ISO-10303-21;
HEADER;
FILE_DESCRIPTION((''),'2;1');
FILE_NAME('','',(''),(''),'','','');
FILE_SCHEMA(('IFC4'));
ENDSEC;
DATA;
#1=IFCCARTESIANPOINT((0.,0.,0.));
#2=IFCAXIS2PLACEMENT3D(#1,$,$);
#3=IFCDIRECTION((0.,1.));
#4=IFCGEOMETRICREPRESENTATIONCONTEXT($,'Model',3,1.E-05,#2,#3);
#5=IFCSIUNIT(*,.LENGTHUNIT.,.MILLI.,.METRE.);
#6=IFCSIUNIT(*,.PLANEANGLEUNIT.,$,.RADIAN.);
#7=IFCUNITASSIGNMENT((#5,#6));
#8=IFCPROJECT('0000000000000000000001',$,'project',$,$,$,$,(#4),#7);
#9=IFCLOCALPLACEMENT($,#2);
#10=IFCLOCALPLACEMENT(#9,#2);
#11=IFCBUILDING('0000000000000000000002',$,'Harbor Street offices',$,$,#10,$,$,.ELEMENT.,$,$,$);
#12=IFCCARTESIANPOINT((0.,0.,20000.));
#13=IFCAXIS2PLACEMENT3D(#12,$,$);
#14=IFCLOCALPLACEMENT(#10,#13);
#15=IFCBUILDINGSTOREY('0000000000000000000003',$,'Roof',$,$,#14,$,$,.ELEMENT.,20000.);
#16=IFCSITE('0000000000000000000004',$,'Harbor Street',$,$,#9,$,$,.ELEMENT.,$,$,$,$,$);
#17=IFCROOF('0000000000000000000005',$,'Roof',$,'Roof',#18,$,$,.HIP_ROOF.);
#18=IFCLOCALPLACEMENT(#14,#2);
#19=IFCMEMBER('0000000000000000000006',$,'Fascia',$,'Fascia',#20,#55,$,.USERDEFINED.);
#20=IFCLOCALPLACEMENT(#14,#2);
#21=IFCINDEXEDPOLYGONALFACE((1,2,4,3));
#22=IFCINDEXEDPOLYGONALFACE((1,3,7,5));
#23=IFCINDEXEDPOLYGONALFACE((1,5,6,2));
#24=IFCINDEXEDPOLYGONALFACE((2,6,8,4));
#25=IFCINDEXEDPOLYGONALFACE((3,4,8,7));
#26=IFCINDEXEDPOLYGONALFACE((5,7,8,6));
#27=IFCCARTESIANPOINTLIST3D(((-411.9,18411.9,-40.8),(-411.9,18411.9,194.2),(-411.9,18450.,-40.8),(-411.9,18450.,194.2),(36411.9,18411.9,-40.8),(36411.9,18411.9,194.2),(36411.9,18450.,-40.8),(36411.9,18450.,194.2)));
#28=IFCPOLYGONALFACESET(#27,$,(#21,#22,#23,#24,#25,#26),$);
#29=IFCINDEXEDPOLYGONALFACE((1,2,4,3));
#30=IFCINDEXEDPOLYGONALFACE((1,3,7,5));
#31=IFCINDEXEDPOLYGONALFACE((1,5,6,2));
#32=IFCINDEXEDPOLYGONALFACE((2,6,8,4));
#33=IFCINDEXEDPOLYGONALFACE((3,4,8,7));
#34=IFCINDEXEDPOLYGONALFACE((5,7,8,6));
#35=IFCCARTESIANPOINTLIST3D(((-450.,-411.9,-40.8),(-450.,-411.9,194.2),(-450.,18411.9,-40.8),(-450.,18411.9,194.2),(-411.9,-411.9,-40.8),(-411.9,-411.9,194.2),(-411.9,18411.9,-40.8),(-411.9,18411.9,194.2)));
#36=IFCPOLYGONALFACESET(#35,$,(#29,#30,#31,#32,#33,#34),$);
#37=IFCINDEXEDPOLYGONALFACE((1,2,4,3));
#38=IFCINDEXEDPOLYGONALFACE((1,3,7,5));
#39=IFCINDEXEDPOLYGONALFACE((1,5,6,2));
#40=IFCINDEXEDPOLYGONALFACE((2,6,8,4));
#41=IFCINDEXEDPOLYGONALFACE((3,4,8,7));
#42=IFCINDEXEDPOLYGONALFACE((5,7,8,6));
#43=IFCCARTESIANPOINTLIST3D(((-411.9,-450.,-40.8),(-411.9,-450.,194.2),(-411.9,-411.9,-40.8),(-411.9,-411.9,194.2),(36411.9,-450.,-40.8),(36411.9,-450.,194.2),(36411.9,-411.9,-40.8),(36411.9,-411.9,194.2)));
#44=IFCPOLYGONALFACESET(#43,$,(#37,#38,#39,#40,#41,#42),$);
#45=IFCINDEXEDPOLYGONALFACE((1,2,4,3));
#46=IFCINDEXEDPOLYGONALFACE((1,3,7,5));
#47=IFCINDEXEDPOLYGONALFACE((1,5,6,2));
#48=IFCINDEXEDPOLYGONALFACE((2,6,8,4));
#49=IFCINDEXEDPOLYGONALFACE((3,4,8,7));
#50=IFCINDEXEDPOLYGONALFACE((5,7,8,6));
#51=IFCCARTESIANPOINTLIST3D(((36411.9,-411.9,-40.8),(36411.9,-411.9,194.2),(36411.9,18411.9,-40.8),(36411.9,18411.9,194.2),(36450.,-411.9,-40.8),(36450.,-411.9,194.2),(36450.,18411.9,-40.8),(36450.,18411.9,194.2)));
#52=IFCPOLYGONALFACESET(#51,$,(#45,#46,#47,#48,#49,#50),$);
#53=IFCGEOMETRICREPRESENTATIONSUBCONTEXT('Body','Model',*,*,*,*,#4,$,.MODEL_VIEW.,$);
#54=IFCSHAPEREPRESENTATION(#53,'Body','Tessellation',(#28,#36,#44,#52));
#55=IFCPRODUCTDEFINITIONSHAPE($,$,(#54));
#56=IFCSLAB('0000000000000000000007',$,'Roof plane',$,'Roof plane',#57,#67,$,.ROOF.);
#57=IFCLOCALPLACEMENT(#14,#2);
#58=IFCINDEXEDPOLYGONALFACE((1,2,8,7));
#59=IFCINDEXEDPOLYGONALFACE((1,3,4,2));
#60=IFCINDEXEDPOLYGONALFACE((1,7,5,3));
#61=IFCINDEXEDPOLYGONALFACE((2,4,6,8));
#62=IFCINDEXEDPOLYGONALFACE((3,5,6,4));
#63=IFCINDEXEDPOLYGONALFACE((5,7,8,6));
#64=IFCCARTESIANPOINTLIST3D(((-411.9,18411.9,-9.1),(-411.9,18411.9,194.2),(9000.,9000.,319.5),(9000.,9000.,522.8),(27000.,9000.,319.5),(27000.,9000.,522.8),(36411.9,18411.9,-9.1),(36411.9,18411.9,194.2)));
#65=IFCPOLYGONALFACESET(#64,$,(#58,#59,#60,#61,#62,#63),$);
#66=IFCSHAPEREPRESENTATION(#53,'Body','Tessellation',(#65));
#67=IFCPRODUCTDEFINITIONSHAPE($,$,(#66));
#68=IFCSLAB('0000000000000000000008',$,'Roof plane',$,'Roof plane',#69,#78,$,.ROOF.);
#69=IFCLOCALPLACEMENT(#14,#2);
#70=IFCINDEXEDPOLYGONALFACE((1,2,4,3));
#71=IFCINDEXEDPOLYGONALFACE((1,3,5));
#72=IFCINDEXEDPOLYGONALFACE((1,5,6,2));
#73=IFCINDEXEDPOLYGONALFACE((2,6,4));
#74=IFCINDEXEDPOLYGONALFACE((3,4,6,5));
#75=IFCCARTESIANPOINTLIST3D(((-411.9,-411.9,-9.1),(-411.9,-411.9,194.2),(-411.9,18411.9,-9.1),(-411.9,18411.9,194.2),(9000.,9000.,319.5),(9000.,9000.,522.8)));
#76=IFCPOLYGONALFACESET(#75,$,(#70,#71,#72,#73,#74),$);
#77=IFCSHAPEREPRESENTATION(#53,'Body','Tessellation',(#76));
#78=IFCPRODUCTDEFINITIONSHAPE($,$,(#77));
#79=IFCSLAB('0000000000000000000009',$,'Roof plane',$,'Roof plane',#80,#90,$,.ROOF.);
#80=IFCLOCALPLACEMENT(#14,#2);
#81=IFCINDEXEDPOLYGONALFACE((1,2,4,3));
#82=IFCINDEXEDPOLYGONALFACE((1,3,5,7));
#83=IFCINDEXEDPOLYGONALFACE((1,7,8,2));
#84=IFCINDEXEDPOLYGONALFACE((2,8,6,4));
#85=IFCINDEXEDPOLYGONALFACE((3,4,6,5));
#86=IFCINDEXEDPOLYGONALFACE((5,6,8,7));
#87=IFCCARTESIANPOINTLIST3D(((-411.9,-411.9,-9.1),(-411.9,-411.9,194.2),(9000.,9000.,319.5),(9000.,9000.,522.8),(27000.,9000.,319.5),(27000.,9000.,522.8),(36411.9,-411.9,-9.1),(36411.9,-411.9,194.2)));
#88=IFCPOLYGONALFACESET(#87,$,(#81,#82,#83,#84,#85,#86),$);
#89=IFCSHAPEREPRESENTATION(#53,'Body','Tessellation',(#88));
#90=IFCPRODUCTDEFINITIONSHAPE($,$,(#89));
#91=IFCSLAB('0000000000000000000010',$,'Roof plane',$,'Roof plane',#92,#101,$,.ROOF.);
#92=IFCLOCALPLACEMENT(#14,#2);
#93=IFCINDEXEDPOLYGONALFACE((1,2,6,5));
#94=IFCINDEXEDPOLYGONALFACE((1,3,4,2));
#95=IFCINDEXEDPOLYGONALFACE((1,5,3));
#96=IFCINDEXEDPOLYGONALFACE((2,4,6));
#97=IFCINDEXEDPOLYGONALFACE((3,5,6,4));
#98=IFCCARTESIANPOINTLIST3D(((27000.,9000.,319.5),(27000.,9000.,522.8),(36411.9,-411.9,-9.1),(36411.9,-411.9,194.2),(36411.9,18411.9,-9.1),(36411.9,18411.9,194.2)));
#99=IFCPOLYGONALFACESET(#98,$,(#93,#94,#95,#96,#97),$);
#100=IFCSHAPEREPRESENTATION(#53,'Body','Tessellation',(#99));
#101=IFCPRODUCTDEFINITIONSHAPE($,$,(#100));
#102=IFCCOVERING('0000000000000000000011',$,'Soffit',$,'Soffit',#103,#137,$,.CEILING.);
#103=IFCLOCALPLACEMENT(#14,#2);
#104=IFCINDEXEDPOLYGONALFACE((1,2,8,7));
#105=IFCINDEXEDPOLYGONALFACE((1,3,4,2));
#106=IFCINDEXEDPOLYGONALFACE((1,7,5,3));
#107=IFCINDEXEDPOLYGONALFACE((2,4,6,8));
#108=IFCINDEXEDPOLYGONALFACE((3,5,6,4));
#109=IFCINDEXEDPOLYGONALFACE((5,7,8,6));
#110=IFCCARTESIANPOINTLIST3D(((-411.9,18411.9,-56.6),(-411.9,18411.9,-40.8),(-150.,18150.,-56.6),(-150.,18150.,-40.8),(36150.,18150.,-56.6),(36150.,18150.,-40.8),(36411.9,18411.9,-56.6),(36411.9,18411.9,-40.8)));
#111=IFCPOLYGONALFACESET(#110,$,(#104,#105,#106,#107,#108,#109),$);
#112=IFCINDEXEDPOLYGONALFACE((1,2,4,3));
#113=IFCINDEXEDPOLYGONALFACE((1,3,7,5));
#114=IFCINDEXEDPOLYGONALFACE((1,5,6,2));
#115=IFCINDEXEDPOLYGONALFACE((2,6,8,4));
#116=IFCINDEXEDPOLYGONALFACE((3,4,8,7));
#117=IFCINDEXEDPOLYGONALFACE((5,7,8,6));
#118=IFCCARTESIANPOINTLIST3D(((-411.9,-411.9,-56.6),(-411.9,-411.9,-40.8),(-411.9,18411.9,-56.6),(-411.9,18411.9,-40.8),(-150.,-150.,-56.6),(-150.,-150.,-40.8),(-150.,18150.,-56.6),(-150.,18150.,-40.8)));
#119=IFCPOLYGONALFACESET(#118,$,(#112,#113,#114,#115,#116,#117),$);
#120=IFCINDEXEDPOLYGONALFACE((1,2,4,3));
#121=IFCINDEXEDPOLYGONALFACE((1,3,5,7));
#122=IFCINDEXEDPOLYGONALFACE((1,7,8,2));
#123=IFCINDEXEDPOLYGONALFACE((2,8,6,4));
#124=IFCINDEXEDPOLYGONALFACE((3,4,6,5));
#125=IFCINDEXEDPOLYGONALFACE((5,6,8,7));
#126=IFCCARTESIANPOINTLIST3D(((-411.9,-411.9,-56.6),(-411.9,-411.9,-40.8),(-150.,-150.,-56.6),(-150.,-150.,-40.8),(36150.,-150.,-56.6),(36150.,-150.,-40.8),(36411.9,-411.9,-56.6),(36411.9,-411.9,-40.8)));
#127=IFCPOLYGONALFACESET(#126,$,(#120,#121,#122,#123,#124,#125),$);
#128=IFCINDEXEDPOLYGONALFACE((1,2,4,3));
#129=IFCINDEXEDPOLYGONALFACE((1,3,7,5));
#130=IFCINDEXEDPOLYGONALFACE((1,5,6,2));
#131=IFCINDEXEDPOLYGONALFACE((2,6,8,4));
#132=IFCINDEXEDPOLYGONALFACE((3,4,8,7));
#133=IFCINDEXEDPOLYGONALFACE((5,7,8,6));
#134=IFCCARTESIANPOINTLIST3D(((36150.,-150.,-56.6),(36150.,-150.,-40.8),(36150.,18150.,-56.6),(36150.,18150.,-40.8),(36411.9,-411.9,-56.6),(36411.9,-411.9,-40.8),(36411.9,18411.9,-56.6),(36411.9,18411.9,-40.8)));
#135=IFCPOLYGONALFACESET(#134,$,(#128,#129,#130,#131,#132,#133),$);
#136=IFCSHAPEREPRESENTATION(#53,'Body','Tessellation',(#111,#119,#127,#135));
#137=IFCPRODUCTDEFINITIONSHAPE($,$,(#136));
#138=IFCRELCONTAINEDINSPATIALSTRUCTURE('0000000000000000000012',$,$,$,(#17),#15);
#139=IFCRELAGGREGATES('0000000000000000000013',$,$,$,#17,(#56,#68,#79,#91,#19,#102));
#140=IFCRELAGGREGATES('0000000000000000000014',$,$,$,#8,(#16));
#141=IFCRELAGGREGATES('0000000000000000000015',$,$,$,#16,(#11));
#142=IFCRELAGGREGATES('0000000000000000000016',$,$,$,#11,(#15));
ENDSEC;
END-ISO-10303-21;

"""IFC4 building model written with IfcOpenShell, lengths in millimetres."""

from ifc_helpers import new_model, si_unit, direction, frame, origin, origin_with_axes, place, context, subcontext, project, spatial, polyline, outline, extrude, element, aggregate, save


model = new_model("IFC4")

# Units and contexts
model_context = context("Model", 3, precision=1e-05, world=origin(), true_north=direction((0.0, 1.0)))
body_context = subcontext(model_context, "Body", "Model", "MODEL_VIEW")
ifc_project = project(units=[si_unit("LENGTHUNIT", "METRE", prefix="MILLI"), si_unit("PLANEANGLEUNIT", "RADIAN")], contexts=[model_context])

# Site, building, storey
site_placement = place(None, origin())
site = spatial("IfcSite", under=ifc_project, at=site_placement, Name="Harbor Street", CompositionType="ELEMENT")
building_placement = place(site_placement, origin())
building = spatial("IfcBuilding", under=site, at=building_placement, Name="Harbor Street offices", CompositionType="ELEMENT")
storey_placement = place(building_placement, frame((0.0, 0.0, 20000.0)))
storey = spatial("IfcBuildingStorey", under=building, at=storey_placement, Name="Roof", CompositionType="ELEMENT", Elevation=20000.0)

# Roof, member, slabs, covering
roof_placement = place(storey_placement, origin_with_axes())
roof = element("IfcRoof", 1, at=roof_placement, inside=storey, Name="Roof", ObjectType="Roof", PredefinedType="HIP_ROOF")
member_placement = place(storey_placement, origin_with_axes())
member = element("IfcMember", 2, at=member_placement, Name="Fascia", ObjectType="Fascia", PredefinedType="USERDEFINED", context=body_context, shape_type="SweptSolid", body=[
    extrude(outline(polyline([(0.0, -234.9), (36823.8, -234.9), (36823.8, 0.0), (0.0, 0.0), (0.0, -234.9)])), frame((36411.9, 18411.9, 194.2), z_axis=(0.0, 1.0, 0.0), x_axis=(-1.0, 0.0, 0.0)), (0.0, 0.0, 1.0), 38.1),
    extrude(outline(polyline([(0.0, -234.9), (18823.8, -234.9), (18823.8, 0.0), (0.0, 0.0), (0.0, -234.9)])), frame((-411.9, 18411.9, 194.2), z_axis=(-1.0, 0.0, 0.0), x_axis=(0.0, -1.0, 0.0)), (0.0, 0.0, 1.0), 38.1),
    extrude(outline(polyline([(0.0, -234.9), (36823.8, -234.9), (36823.8, 0.0), (0.0, 0.0), (0.0, -234.9)])), frame((-411.9, -411.9, 194.2), z_axis=(0.0, -1.0, 0.0), x_axis=(1.0, 0.0, 0.0)), (0.0, 0.0, 1.0), 38.1),
    extrude(outline(polyline([(0.0, -234.9), (18823.8, -234.9), (18823.8, 0.0), (0.0, 0.0), (0.0, -234.9)])), frame((36411.9, -411.9, 194.2), z_axis=(1.0, 0.0, 0.0), x_axis=(0.0, 1.0, 0.0)), (0.0, 0.0, 1.0), 38.1),
])
slab_1_placement = place(storey_placement, origin_with_axes())
slab_1 = element("IfcSlab", 3, at=slab_1_placement, Name="Roof plane", ObjectType="Roof plane", PredefinedType="ROOF", context=body_context, shape_type="SweptSolid", body=[
    extrude(outline(polyline([(-36411.9, 0.0), (411.9, 0.0), (-9000.0, 9417.6), (-27000.0, 9417.6), (-36411.9, 0.0)])), frame((0.0, 18411.9, -9.1), z_axis=(0.0, 0.034899, 0.999391), x_axis=(-1.0, 0.0, 0.0)), (0.0, 0.034899, 0.999391), 203.3),
])
slab_2_placement = place(storey_placement, origin_with_axes())
slab_2 = element("IfcSlab", 4, at=slab_2_placement, Name="Roof plane", ObjectType="Roof plane", PredefinedType="ROOF", context=body_context, shape_type="SweptSolid", body=[
    extrude(outline(polyline([(-18411.9, 0.0), (411.9, 0.0), (-9000.0, 9417.6), (-18411.9, 0.0)])), frame((-411.9, 0.0, -9.1), z_axis=(-0.034899, 0.0, 0.999391), x_axis=(0.0, -1.0, 0.0)), (0.0, 0.034899, 0.999391), 203.3),
])
slab_3_placement = place(storey_placement, origin_with_axes())
slab_3 = element("IfcSlab", 5, at=slab_3_placement, Name="Roof plane", ObjectType="Roof plane", PredefinedType="ROOF", context=body_context, shape_type="SweptSolid", body=[
    extrude(outline(polyline([(-411.9, 0.0), (36411.9, 0.0), (27000.0, 9417.6), (9000.0, 9417.6), (-411.9, 0.0)])), frame((0.0, -411.9, -9.1), z_axis=(0.0, -0.034899, 0.999391), x_axis=(1.0, 0.0, 0.0)), (0.0, 0.034899, 0.999391), 203.3),
])
slab_4_placement = place(storey_placement, origin_with_axes())
slab_4 = element("IfcSlab", 6, at=slab_4_placement, Name="Roof plane", ObjectType="Roof plane", PredefinedType="ROOF", context=body_context, shape_type="SweptSolid", body=[
    extrude(outline(polyline([(-411.9, 0.0), (18411.9, 0.0), (9000.0, 9417.6), (-411.9, 0.0)])), frame((36411.9, 0.0, -9.1), z_axis=(0.034899, 0.0, 0.999391), x_axis=(0.0, 1.0, 0.0)), (0.0, 0.034899, 0.999391), 203.3),
])
covering_placement = place(storey_placement, origin_with_axes())
covering = element("IfcCovering", 7, at=covering_placement, Name="Soffit", ObjectType="Soffit", PredefinedType="CEILING", context=body_context, shape_type="SweptSolid", body=[
    extrude(outline(polyline([(36150.0, 18150.0), (-150.0, 18150.0), (-411.9, 18411.9), (36411.9, 18411.9), (36150.0, 18150.0)])), frame((0.0, 0.0, -56.6), z_axis=(0.0, 0.0, 1.0), x_axis=(1.0, 0.0, 0.0)), (0.0, 0.0, 1.0), 15.9),
    extrude(outline(polyline([(-150.0, 18150.0), (-150.0, -150.0), (-411.9, -411.9), (-411.9, 18411.9), (-150.0, 18150.0)])), frame((0.0, 0.0, -56.6), z_axis=(0.0, 0.0, 1.0), x_axis=(1.0, 0.0, 0.0)), (0.0, 0.0, 1.0), 15.9),
    extrude(outline(polyline([(-150.0, -150.0), (36150.0, -150.0), (36411.9, -411.9), (-411.9, -411.9), (-150.0, -150.0)])), frame((0.0, 0.0, -56.6), z_axis=(0.0, 0.0, 1.0), x_axis=(1.0, 0.0, 0.0)), (0.0, 0.0, 1.0), 15.9),
    extrude(outline(polyline([(36150.0, -150.0), (36150.0, 18150.0), (36411.9, 18411.9), (36411.9, -411.9), (36150.0, -150.0)])), frame((0.0, 0.0, -56.6), z_axis=(0.0, 0.0, 1.0), x_axis=(1.0, 0.0, 0.0)), (0.0, 0.0, 1.0), 15.9),
])
aggregate(roof, [slab_1, slab_2, slab_3, slab_4, member, covering])

save(model, "model.ifc")
